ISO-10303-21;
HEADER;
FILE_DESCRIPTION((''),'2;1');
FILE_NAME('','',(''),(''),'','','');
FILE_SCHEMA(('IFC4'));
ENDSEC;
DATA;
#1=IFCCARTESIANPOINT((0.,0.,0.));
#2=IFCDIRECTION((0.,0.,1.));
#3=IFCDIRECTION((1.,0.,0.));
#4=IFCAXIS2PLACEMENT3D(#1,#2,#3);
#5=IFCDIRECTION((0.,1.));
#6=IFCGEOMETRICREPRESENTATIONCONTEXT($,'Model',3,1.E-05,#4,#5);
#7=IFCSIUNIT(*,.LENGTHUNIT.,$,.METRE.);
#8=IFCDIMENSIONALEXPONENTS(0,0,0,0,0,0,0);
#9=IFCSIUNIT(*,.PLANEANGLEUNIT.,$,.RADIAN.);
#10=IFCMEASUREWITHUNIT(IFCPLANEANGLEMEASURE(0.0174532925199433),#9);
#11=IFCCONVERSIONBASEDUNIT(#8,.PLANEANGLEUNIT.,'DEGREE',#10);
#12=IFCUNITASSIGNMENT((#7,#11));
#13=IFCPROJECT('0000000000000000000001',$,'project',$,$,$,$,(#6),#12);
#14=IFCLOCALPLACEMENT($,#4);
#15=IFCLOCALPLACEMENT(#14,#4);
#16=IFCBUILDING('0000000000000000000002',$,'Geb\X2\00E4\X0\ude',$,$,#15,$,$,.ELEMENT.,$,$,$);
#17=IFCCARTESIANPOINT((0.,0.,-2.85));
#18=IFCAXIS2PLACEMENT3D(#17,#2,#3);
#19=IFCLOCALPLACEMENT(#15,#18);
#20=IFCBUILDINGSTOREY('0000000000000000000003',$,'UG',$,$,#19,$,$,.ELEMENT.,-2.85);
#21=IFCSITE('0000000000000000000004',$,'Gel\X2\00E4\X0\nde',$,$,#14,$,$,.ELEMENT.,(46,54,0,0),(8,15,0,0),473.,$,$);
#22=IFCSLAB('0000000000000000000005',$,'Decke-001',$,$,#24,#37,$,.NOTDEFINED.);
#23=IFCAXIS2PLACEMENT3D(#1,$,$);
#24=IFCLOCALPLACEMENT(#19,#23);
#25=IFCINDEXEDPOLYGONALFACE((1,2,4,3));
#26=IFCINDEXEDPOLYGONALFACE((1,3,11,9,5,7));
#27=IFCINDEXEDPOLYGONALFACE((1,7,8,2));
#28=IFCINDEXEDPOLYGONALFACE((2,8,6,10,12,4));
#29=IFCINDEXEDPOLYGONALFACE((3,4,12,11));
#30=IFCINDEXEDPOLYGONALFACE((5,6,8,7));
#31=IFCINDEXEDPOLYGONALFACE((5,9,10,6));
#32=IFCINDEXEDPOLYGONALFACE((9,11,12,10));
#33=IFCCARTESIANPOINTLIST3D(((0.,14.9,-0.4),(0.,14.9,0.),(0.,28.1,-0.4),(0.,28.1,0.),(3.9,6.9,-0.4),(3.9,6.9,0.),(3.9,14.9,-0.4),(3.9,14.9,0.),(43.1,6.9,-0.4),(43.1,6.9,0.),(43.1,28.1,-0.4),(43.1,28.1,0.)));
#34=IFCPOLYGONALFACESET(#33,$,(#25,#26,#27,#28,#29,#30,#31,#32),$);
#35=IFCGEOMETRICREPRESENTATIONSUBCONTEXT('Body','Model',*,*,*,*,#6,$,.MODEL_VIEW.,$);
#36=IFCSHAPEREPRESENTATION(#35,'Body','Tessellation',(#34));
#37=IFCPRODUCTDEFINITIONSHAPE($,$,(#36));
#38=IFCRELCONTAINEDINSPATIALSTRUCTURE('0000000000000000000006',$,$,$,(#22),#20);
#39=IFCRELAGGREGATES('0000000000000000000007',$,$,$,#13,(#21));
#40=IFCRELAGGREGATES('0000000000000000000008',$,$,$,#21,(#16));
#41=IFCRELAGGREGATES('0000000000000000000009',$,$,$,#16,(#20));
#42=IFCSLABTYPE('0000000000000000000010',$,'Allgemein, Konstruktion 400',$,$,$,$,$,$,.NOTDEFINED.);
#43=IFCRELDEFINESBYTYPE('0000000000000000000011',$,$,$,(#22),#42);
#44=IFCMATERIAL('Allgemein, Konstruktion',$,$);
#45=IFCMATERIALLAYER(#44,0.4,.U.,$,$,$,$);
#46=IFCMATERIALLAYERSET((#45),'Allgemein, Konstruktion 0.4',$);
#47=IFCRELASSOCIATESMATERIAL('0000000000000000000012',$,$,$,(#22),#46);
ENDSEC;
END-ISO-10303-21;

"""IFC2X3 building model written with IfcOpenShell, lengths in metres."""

from ifc_helpers import new_model, entity, si_unit, converted_unit, direction, frame, origin_with_axes, place, context, subcontext, project, spatial, polyline, outline, extrude, material, layer, layer_set, layer_usage, type_object, element, save


model = new_model("IFC2X3")

# Units and contexts
model_context = context("Model", 3, precision=1e-05, world=origin_with_axes(), true_north=direction((0.0, 1.0)))
body_context = subcontext(model_context, "Body", "Model", "MODEL_VIEW")
ifc_project = project(units=[si_unit("LENGTHUNIT", "METRE"), converted_unit("PLANEANGLEUNIT", "DEGREE", entity("IfcPlaneAngleMeasure", 0.0174532925199433), si_unit("PLANEANGLEUNIT", "RADIAN"), dimensions=[0, 0, 0, 0, 0, 0, 0])], contexts=[model_context])

# Site, building, storey
site_placement = place(None, origin_with_axes())
site = spatial("IfcSite", under=ifc_project, at=site_placement, Name="Gelände", CompositionType="ELEMENT", RefLatitude=(46, 54, 0, 0), RefLongitude=(8, 15, 0, 0), RefElevation=473.0)
building_placement = place(site_placement, origin_with_axes())
building = spatial("IfcBuilding", under=site, at=building_placement, Name="Gebäude", CompositionType="ELEMENT")
storey_placement = place(building_placement, frame((0.0, 0.0, -2.85), z_axis=(0.0, 0.0, 1.0), x_axis=(1.0, 0.0, 0.0)))
storey = spatial("IfcBuildingStorey", under=building, at=storey_placement, Name="UG", CompositionType="ELEMENT", Elevation=-2.85)

# Slab
ifc_material = material(Name="Allgemein, Konstruktion")
ifc_layer = layer(ifc_material, 0.4, ventilated="UNKNOWN")
ifc_layer_set = layer_set([ifc_layer], Name="Allgemein, Konstruktion 0.4")
ifc_layer_usage = layer_usage(ifc_layer_set, "AXIS3", "NEGATIVE", 0.4)
slab_type = type_object("IfcSlabType", Name="Allgemein, Konstruktion 400", PredefinedType="NOTDEFINED")
slab_placement = place(storey_placement, frame((0.0, 28.1, 0.0), z_axis=(0.0, 0.0, 1.0), x_axis=(1.0, 0.0, 0.0)))
element("IfcSlab", 1, at=slab_placement, inside=storey, type_object=slab_type, material=ifc_layer_usage, Name="Decke-001", PredefinedType="NOTDEFINED", context=body_context, shape_type="SweptSolid", body=[
    extrude(outline(polyline([(0.0, 0.0), (0.0, -13.2), (3.9, -13.2), (3.9, -21.2), (43.1, -21.2), (43.1, 0.0), (0.0, 0.0)])), frame((0.0, 0.0, -0.4), z_axis=(0.0, 0.0, 1.0), x_axis=(1.0, 0.0, 0.0)), (0.0, 0.0, 1.0), 0.4),
])

save(model, "model.ifc")
